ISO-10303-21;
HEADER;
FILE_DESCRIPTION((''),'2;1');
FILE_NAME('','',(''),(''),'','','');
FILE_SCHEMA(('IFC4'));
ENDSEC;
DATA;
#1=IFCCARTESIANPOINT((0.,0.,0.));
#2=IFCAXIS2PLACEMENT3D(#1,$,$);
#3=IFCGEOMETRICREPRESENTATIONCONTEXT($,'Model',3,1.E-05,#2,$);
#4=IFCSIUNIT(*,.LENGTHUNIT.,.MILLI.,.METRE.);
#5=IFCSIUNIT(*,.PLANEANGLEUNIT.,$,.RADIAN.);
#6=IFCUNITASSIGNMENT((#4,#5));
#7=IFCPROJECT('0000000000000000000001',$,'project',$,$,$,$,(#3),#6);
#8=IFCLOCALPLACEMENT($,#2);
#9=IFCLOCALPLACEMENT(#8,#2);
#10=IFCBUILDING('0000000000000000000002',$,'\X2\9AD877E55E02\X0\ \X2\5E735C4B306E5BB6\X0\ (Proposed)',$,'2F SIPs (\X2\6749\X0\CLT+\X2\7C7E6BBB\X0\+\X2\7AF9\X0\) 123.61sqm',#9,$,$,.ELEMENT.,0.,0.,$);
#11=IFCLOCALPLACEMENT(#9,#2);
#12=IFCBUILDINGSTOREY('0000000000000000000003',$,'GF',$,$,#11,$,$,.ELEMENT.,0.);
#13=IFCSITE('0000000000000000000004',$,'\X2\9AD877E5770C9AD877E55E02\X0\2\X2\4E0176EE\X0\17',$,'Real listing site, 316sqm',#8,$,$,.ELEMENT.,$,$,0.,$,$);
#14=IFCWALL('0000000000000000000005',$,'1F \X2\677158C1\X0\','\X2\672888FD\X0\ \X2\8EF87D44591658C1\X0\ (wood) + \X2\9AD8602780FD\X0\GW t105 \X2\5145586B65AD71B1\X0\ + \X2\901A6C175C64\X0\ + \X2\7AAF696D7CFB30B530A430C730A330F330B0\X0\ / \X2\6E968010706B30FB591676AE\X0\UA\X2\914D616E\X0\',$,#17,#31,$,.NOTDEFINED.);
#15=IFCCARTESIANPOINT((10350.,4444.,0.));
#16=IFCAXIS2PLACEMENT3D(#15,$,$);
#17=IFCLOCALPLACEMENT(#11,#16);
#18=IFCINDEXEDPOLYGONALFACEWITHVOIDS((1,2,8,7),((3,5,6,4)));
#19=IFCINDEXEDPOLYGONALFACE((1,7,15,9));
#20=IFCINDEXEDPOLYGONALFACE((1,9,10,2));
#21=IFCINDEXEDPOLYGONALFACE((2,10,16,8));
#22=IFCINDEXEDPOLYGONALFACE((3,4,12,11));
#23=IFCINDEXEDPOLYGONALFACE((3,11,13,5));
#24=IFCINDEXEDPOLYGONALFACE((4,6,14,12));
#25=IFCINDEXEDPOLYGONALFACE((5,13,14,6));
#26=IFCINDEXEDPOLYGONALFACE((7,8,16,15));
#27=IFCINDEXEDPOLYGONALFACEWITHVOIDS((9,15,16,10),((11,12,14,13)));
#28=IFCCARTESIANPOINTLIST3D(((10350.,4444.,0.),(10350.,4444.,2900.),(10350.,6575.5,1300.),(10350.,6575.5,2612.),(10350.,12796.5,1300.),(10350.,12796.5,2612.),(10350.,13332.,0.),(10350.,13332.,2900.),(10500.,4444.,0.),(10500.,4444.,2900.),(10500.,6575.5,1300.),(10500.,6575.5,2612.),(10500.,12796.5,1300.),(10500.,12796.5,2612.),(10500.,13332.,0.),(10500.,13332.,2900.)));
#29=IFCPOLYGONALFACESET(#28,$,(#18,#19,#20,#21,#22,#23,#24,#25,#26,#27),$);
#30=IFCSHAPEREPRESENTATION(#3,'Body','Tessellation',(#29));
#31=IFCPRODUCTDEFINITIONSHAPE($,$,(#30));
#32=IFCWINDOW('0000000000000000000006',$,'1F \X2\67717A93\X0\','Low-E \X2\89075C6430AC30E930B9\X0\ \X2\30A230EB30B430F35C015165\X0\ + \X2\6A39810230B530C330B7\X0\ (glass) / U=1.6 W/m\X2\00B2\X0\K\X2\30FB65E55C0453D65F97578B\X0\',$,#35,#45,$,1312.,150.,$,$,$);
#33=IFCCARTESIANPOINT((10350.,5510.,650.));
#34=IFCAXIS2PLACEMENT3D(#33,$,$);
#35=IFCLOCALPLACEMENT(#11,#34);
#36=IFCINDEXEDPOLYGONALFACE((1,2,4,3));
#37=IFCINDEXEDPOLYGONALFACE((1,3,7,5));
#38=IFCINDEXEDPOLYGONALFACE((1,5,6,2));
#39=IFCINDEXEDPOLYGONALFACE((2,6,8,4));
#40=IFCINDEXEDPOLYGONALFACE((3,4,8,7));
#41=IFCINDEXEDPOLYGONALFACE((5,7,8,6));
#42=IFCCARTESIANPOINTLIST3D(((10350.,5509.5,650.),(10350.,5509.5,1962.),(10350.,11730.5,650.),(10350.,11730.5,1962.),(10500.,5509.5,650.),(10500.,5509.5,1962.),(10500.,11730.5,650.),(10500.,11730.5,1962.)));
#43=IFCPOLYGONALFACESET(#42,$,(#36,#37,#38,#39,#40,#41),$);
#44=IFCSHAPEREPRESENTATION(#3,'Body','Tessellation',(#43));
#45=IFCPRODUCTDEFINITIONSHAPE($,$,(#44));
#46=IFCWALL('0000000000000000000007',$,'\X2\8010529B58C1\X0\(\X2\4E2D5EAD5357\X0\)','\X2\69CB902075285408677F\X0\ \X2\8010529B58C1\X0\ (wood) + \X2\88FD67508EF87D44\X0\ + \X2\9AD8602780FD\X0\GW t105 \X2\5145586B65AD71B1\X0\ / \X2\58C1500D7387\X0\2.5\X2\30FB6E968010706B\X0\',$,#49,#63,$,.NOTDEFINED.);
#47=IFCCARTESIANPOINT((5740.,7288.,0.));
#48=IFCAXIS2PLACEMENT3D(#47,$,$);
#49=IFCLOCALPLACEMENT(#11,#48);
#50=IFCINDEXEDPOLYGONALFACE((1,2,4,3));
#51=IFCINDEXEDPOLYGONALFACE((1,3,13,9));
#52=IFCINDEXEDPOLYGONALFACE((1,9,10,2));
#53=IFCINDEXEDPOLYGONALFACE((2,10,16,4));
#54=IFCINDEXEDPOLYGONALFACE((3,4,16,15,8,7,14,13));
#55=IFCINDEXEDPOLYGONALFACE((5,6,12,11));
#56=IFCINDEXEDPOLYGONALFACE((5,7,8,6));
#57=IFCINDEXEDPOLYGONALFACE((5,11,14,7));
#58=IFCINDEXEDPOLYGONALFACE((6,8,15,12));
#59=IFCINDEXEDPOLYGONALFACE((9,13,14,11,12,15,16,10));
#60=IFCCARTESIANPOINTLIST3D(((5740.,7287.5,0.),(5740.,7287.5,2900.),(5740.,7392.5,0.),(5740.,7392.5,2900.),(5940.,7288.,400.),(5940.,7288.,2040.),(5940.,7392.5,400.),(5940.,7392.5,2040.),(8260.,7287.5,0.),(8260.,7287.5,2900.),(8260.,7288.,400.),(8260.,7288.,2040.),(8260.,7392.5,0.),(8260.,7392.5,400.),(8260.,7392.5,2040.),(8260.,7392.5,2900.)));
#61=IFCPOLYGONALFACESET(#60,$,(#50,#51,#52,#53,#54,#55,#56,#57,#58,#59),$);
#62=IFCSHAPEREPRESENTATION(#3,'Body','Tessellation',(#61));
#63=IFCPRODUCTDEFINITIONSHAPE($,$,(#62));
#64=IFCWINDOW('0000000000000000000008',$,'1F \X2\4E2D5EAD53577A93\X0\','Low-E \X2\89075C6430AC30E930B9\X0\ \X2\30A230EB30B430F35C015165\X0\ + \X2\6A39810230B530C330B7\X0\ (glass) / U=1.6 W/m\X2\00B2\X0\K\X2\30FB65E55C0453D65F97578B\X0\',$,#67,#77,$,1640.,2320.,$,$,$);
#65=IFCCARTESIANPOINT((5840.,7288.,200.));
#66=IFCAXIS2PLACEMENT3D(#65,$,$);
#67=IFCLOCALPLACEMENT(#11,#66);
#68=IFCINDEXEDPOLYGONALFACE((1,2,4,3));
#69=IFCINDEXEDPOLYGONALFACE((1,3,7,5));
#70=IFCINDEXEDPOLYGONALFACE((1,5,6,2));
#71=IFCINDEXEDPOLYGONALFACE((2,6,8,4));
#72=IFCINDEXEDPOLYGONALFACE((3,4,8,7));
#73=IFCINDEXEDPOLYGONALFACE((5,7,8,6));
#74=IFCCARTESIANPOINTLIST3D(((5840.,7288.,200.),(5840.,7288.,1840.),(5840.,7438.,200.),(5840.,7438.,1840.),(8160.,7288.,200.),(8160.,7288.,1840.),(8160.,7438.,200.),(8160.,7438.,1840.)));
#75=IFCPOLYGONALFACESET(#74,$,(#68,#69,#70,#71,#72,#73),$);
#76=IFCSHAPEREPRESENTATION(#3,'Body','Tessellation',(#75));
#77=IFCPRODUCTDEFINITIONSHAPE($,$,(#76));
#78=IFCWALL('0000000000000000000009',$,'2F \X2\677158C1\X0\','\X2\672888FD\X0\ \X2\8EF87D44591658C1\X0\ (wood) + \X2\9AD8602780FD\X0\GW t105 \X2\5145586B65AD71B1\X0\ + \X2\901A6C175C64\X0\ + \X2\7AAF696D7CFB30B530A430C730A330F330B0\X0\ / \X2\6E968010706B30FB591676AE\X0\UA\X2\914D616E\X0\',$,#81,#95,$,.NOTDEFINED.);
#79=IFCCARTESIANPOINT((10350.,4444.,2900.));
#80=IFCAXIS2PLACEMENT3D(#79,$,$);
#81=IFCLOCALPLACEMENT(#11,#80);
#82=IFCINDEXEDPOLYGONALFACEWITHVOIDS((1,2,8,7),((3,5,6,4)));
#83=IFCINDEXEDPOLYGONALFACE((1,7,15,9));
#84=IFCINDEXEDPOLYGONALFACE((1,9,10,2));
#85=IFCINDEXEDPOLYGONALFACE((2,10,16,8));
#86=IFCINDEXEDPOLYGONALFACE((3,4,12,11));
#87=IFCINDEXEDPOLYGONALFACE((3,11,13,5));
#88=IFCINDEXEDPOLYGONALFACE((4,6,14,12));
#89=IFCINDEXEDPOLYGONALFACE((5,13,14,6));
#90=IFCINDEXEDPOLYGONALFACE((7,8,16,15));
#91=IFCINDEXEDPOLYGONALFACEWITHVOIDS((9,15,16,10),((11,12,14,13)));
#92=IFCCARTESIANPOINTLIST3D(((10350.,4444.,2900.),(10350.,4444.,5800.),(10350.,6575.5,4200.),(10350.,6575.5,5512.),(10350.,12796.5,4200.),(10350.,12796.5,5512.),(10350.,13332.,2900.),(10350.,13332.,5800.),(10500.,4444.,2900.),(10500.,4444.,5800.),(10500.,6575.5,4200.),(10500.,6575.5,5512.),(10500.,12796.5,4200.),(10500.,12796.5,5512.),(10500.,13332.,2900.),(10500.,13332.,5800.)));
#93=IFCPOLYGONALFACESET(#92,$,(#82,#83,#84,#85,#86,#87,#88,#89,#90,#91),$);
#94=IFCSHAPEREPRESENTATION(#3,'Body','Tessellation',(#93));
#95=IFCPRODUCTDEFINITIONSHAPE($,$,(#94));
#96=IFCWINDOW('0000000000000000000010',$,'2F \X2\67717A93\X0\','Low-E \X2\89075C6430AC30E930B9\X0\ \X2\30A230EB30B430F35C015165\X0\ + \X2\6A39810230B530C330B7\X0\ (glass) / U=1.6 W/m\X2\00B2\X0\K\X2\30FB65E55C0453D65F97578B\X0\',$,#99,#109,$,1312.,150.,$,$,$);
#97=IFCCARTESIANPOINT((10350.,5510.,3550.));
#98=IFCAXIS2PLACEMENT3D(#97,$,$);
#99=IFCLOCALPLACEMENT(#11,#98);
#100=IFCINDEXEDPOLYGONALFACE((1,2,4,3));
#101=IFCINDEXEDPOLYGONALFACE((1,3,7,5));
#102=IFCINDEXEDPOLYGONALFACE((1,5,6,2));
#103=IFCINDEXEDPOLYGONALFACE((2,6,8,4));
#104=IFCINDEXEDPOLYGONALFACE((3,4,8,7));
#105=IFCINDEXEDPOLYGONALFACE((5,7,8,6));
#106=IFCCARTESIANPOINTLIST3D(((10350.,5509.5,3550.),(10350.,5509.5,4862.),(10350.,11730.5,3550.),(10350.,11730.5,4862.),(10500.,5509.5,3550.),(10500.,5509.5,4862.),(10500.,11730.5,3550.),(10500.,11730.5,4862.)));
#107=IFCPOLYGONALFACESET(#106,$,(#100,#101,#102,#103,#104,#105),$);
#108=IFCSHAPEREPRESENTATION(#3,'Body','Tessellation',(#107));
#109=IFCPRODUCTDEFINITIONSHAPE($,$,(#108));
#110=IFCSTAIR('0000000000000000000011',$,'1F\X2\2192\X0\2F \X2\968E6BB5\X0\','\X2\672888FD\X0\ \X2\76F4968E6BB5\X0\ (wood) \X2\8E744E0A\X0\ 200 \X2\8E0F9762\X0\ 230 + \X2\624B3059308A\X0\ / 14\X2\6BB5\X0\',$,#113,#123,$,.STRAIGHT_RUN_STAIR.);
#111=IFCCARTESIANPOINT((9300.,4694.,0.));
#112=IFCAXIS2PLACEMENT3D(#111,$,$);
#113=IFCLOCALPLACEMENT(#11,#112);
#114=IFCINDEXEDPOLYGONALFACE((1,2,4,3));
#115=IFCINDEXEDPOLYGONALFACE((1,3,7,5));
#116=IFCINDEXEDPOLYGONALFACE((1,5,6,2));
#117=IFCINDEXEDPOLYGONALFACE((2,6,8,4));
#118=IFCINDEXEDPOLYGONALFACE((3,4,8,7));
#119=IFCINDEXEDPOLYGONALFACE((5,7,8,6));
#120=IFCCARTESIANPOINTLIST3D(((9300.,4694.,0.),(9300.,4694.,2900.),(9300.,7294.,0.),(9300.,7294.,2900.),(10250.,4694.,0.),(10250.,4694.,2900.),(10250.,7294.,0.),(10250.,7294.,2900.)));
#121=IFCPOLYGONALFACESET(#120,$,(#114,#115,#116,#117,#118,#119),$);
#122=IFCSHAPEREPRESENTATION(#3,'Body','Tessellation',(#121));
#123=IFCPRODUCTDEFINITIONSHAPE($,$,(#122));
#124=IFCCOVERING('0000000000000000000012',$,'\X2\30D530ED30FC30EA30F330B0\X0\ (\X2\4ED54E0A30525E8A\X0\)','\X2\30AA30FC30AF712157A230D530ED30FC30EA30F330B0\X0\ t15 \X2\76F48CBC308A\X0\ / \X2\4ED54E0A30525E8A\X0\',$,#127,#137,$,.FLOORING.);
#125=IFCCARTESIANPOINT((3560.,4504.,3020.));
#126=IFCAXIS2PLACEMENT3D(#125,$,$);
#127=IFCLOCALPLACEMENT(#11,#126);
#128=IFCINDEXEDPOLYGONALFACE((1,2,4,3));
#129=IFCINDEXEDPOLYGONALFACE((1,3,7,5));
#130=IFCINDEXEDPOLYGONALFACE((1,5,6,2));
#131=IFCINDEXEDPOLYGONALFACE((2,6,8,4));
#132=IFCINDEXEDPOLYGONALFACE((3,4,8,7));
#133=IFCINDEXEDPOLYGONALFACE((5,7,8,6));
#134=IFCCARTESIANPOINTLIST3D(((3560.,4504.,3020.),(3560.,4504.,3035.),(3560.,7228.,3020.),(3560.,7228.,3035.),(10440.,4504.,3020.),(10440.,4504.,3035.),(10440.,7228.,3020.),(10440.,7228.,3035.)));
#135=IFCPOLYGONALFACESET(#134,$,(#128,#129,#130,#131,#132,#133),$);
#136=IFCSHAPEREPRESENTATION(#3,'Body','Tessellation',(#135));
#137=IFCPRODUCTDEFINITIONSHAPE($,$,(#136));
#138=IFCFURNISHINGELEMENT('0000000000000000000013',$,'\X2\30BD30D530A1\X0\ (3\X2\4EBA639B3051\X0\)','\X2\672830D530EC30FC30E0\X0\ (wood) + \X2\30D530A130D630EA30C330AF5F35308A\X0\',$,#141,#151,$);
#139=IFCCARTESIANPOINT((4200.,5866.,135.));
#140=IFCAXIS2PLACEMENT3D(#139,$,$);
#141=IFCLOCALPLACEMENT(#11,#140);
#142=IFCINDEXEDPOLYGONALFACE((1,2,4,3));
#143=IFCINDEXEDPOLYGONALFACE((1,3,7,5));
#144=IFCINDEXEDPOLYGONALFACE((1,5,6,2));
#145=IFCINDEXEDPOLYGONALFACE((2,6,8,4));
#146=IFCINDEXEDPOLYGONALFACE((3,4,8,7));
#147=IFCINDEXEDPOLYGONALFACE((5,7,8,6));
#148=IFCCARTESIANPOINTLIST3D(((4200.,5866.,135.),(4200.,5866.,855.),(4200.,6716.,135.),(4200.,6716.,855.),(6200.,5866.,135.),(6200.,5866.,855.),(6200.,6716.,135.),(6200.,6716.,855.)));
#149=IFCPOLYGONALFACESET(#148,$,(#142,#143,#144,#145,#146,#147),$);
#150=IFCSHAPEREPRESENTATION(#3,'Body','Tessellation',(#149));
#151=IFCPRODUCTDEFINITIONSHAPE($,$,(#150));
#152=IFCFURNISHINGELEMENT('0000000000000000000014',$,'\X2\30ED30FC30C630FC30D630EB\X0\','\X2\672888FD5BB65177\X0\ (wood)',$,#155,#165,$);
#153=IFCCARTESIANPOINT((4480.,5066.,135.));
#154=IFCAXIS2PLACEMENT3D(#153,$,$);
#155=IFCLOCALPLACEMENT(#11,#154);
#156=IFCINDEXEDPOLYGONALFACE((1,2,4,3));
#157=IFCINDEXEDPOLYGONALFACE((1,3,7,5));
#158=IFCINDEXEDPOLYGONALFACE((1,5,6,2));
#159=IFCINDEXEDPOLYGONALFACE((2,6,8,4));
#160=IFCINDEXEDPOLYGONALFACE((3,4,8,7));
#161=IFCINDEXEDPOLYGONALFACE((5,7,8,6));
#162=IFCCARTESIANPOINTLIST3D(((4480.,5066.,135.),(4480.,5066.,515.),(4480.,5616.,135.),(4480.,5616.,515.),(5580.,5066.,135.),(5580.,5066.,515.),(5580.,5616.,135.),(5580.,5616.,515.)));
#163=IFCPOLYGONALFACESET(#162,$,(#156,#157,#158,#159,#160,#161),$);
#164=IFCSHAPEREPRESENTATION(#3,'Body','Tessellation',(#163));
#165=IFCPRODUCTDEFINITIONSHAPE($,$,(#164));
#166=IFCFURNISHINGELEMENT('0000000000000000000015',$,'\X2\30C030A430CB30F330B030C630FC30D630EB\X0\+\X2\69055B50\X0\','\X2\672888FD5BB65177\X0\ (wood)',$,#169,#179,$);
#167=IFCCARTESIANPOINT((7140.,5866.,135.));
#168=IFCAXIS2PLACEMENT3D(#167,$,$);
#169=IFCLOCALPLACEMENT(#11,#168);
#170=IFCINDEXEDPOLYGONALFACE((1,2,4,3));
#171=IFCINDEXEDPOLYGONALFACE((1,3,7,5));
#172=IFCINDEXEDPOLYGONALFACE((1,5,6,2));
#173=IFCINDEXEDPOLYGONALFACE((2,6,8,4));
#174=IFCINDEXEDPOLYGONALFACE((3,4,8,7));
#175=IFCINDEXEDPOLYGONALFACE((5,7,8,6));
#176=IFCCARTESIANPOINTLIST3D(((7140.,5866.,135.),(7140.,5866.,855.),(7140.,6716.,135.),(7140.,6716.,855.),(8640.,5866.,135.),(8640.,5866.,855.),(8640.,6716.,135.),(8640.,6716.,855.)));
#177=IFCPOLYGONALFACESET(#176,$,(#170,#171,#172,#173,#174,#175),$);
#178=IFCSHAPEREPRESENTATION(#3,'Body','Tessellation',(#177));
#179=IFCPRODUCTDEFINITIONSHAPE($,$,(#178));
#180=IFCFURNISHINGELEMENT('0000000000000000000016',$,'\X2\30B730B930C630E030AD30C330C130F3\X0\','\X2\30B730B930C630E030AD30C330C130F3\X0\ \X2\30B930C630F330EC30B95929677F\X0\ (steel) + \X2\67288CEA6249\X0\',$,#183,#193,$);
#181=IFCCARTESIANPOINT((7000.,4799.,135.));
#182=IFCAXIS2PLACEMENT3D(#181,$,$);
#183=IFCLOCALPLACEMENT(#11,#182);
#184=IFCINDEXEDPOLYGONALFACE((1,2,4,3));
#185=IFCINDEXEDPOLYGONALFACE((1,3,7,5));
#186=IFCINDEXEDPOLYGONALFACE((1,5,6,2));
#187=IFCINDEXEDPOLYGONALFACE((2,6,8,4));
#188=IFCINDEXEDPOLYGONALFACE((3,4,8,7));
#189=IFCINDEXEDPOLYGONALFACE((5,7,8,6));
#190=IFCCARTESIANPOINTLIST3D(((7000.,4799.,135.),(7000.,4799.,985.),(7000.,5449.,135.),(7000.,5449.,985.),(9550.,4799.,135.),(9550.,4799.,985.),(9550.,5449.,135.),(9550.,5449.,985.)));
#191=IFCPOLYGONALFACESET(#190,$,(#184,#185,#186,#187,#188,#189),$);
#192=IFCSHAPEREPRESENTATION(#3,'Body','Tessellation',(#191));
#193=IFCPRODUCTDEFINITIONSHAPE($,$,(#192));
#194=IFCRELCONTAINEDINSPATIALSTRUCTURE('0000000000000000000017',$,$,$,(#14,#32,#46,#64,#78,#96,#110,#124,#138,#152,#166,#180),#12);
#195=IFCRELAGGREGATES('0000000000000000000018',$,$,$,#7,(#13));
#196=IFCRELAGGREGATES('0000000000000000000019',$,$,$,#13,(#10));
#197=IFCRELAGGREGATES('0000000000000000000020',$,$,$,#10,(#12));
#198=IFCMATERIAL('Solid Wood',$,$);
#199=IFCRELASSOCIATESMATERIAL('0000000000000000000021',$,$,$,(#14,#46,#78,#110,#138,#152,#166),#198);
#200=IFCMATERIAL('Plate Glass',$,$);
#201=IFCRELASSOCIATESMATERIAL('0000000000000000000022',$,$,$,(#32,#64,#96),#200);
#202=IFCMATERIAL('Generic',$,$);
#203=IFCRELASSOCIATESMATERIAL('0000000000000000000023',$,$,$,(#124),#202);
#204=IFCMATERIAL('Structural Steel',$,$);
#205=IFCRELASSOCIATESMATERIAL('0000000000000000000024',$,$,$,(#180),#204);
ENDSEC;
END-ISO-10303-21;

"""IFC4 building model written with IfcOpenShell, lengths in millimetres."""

from ifc_helpers import new_model, si_unit, frame, frame_2d, origin, place, context, project, spatial, rectangle, extrude, material, element, fill, save


model = new_model("IFC4")

# Units and contexts
model_context = context("Model", 3, precision=1e-05, world=origin())
ifc_project = project(units=[si_unit("LENGTHUNIT", "METRE", prefix="MILLI"), si_unit("PLANEANGLEUNIT", "RADIAN")], contexts=[model_context])

# Site, building, storey
site_placement = place(None, origin())
site = spatial("IfcSite", under=ifc_project, at=site_placement, Name="高知県高知市2丁目17", ObjectType="Real listing site, 316sqm", CompositionType="ELEMENT", RefElevation=0.0)
building_placement = place(site_placement, origin())
building = spatial("IfcBuilding", under=site, at=building_placement, Name="高知市 平屋の家 (Proposed)", ObjectType="2F SIPs (杉CLT+籾殻+竹) 123.61sqm", CompositionType="ELEMENT", ElevationOfRefHeight=0.0, ElevationOfTerrain=0.0)
storey_placement = place(building_placement, origin())
storey = spatial("IfcBuildingStorey", under=building, at=storey_placement, Name="GF", CompositionType="ELEMENT", Elevation=0.0)

# Shared definitions
ifc_material_1 = material(Name="Solid Wood")

# Walls, openings, windows
wall_1_placement = place(storey_placement, frame((10350.0, 4444.0, 0.0)))
wall_1 = element("IfcWall", 1, at=wall_1_placement, inside=storey, material=ifc_material_1, Name="1F 東壁", Description="木製 軸組外壁 (wood) + 高性能GW t105 充填断熱 + 通気層 + 窯業系サイディング / 準耐火・外皮UA配慮", PredefinedType="NOTDEFINED", context=model_context, shape_type="SweptSolid", body=[
    extrude(rectangle(XDim=150.0, YDim=8888.0, at=frame_2d((75.0, 4444.0))), frame((10350.0, 4444.0, 0.0)), (0.0, 0.0, 1.0), 2900.0),
])
opening_1_placement = place(storey_placement, frame((10350.0, 5510.0, 650.0)))
opening_1 = element("IfcOpeningElement", 2, at=opening_1_placement, cuts=wall_1, PredefinedType="NOTDEFINED", context=model_context, shape_type="SweptSolid", body=[
    extrude(rectangle(XDim=150.0, YDim=6221.0, at=frame_2d((75.0, 3110.0))), frame((10350.0, 5510.0, 650.0)), (0.0, 0.0, 1.0), 1312.0),
])
ifc_material_2 = material(Name="Plate Glass")
window_1_placement = place(storey_placement, frame((10350.0, 5510.0, 650.0)))
window_1 = element("IfcWindow", 3, at=window_1_placement, inside=storey, material=ifc_material_2, Name="1F 東窓", Description="Low-E 複層ガラス アルゴン封入 + 樹脂サッシ (glass) / U=1.6 W/m²K・日射取得型", OverallHeight=1312.0, OverallWidth=150.0, context=model_context, shape_type="SweptSolid", body=[
    extrude(rectangle(XDim=150.0, YDim=6221.0, at=frame_2d((75.0, 3110.0))), frame((10350.0, 5510.0, 650.0)), (0.0, 0.0, 1.0), 1312.0),
])
fill(opening_1, window_1)
wall_2_placement = place(storey_placement, frame((5740.0, 7288.0, 0.0)))
wall_2 = element("IfcWall", 4, at=wall_2_placement, inside=storey, material=ifc_material_1, Name="耐力壁(中庭南)", Description="構造用合板 耐力壁 (wood) + 製材軸組 + 高性能GW t105 充填断熱 / 壁倍率2.5・準耐火", PredefinedType="NOTDEFINED", context=model_context, shape_type="SweptSolid", body=[
    extrude(rectangle(XDim=2520.0, YDim=105.0, at=frame_2d((1260.0, 52.0))), frame((5740.0, 7288.0, 0.0)), (0.0, 0.0, 1.0), 2900.0),
])
opening_2_placement = place(storey_placement, frame((5840.0, 7288.0, 200.0)))
opening_2 = element("IfcOpeningElement", 5, at=opening_2_placement, cuts=wall_2, PredefinedType="NOTDEFINED", context=model_context, shape_type="SweptSolid", body=[
    extrude(rectangle(XDim=2320.0, YDim=150.0, at=frame_2d((1160.0, 75.0))), frame((5840.0, 7288.0, 200.0)), (0.0, 0.0, 1.0), 1640.0),
])
window_2_placement = place(storey_placement, frame((5840.0, 7288.0, 200.0)))
window_2 = element("IfcWindow", 6, at=window_2_placement, inside=storey, material=ifc_material_2, Name="1F 中庭南窓", Description="Low-E 複層ガラス アルゴン封入 + 樹脂サッシ (glass) / U=1.6 W/m²K・日射取得型", OverallHeight=1640.0, OverallWidth=2320.0, context=model_context, shape_type="SweptSolid", body=[
    extrude(rectangle(XDim=2320.0, YDim=150.0, at=frame_2d((1160.0, 75.0))), frame((5840.0, 7288.0, 200.0)), (0.0, 0.0, 1.0), 1640.0),
])
fill(opening_2, window_2)

# Wall, opening, window
wall_3_placement = place(storey_placement, frame((10350.0, 4444.0, 2900.0)))
wall_3 = element("IfcWall", 7, at=wall_3_placement, inside=storey, material=ifc_material_1, Name="2F 東壁", Description="木製 軸組外壁 (wood) + 高性能GW t105 充填断熱 + 通気層 + 窯業系サイディング / 準耐火・外皮UA配慮", PredefinedType="NOTDEFINED", context=model_context, shape_type="SweptSolid", body=[
    extrude(rectangle(XDim=150.0, YDim=8888.0, at=frame_2d((75.0, 4444.0))), frame((10350.0, 4444.0, 2900.0)), (0.0, 0.0, 1.0), 2900.0),
])
opening_3_placement = place(storey_placement, frame((10350.0, 5510.0, 3550.0)))
opening_3 = element("IfcOpeningElement", 8, at=opening_3_placement, cuts=wall_3, PredefinedType="NOTDEFINED", context=model_context, shape_type="SweptSolid", body=[
    extrude(rectangle(XDim=150.0, YDim=6221.0, at=frame_2d((75.0, 3110.0))), frame((10350.0, 5510.0, 3550.0)), (0.0, 0.0, 1.0), 1312.0),
])
window_3_placement = place(storey_placement, frame((10350.0, 5510.0, 3550.0)))
window_3 = element("IfcWindow", 9, at=window_3_placement, inside=storey, material=ifc_material_2, Name="2F 東窓", Description="Low-E 複層ガラス アルゴン封入 + 樹脂サッシ (glass) / U=1.6 W/m²K・日射取得型", OverallHeight=1312.0, OverallWidth=150.0, context=model_context, shape_type="SweptSolid", body=[
    extrude(rectangle(XDim=150.0, YDim=6221.0, at=frame_2d((75.0, 3110.0))), frame((10350.0, 5510.0, 3550.0)), (0.0, 0.0, 1.0), 1312.0),
])
fill(opening_3, window_3)

# Stair
stair_placement = place(storey_placement, frame((9300.0, 4694.0, 0.0)))
element("IfcStair", 10, at=stair_placement, inside=storey, material=ifc_material_1, Name="1F→2F 階段", Description="木製 直階段 (wood) 蹴上 200 踏面 230 + 手すり / 14段", PredefinedType="STRAIGHT_RUN_STAIR", context=model_context, shape_type="SweptSolid", body=[
    extrude(rectangle(XDim=950.0, YDim=2600.0, at=frame_2d((475.0, 1300.0))), frame((9300.0, 4694.0, 0.0)), (0.0, 0.0, 1.0), 2900.0),
])

# Covering
ifc_material_3 = material(Name="Generic")
covering_placement = place(storey_placement, frame((3560.0, 4504.0, 3020.0)))
element("IfcCovering", 11, at=covering_placement, inside=storey, material=ifc_material_3, Name="フローリング (仕上げ床)", Description="オーク無垢フローリング t15 直貼り / 仕上げ床", PredefinedType="FLOORING", context=model_context, shape_type="SweptSolid", body=[
    extrude(rectangle(XDim=6880.0, YDim=2724.0, at=frame_2d((3440.0, 1362.0))), frame((3560.0, 4504.0, 3020.0)), (0.0, 0.0, 1.0), 15.0),
])

# Furnishing elements
furnishing_1_placement = place(storey_placement, frame((4200.0, 5866.0, 135.0)))
element("IfcFurnishingElement", 12, at=furnishing_1_placement, inside=storey, material=ifc_material_1, Name="ソファ (3人掛け)", Description="木フレーム (wood) + ファブリック張り", context=model_context, shape_type="SweptSolid", body=[
    extrude(rectangle(XDim=2000.0, YDim=850.0, at=frame_2d((1000.0, 425.0))), frame((4200.0, 5866.0, 135.0)), (0.0, 0.0, 1.0), 720.0),
])
furnishing_2_placement = place(storey_placement, frame((4480.0, 5066.0, 135.0)))
element("IfcFurnishingElement", 13, at=furnishing_2_placement, inside=storey, material=ifc_material_1, Name="ローテーブル", Description="木製家具 (wood)", context=model_context, shape_type="SweptSolid", body=[
    extrude(rectangle(XDim=1100.0, YDim=550.0, at=frame_2d((550.0, 275.0))), frame((4480.0, 5066.0, 135.0)), (0.0, 0.0, 1.0), 380.0),
])
furnishing_3_placement = place(storey_placement, frame((7140.0, 5866.0, 135.0)))
element("IfcFurnishingElement", 14, at=furnishing_3_placement, inside=storey, material=ifc_material_1, Name="ダイニングテーブル+椅子", Description="木製家具 (wood)", context=model_context, shape_type="SweptSolid", body=[
    extrude(rectangle(XDim=1500.0, YDim=850.0, at=frame_2d((750.0, 425.0))), frame((7140.0, 5866.0, 135.0)), (0.0, 0.0, 1.0), 720.0),
])
ifc_material_4 = material(Name="Structural Steel")
furnishing_4_placement = place(storey_placement, frame((7000.0, 4799.0, 135.0)))
element("IfcFurnishingElement", 15, at=furnishing_4_placement, inside=storey, material=ifc_material_4, Name="システムキッチン", Description="システムキッチン ステンレス天板 (steel) + 木質扉", context=model_context, shape_type="SweptSolid", body=[
    extrude(rectangle(XDim=2550.0, YDim=650.0, at=frame_2d((1275.0, 325.0))), frame((7000.0, 4799.0, 135.0)), (0.0, 0.0, 1.0), 850.0),
])

save(model, "model.ifc")
